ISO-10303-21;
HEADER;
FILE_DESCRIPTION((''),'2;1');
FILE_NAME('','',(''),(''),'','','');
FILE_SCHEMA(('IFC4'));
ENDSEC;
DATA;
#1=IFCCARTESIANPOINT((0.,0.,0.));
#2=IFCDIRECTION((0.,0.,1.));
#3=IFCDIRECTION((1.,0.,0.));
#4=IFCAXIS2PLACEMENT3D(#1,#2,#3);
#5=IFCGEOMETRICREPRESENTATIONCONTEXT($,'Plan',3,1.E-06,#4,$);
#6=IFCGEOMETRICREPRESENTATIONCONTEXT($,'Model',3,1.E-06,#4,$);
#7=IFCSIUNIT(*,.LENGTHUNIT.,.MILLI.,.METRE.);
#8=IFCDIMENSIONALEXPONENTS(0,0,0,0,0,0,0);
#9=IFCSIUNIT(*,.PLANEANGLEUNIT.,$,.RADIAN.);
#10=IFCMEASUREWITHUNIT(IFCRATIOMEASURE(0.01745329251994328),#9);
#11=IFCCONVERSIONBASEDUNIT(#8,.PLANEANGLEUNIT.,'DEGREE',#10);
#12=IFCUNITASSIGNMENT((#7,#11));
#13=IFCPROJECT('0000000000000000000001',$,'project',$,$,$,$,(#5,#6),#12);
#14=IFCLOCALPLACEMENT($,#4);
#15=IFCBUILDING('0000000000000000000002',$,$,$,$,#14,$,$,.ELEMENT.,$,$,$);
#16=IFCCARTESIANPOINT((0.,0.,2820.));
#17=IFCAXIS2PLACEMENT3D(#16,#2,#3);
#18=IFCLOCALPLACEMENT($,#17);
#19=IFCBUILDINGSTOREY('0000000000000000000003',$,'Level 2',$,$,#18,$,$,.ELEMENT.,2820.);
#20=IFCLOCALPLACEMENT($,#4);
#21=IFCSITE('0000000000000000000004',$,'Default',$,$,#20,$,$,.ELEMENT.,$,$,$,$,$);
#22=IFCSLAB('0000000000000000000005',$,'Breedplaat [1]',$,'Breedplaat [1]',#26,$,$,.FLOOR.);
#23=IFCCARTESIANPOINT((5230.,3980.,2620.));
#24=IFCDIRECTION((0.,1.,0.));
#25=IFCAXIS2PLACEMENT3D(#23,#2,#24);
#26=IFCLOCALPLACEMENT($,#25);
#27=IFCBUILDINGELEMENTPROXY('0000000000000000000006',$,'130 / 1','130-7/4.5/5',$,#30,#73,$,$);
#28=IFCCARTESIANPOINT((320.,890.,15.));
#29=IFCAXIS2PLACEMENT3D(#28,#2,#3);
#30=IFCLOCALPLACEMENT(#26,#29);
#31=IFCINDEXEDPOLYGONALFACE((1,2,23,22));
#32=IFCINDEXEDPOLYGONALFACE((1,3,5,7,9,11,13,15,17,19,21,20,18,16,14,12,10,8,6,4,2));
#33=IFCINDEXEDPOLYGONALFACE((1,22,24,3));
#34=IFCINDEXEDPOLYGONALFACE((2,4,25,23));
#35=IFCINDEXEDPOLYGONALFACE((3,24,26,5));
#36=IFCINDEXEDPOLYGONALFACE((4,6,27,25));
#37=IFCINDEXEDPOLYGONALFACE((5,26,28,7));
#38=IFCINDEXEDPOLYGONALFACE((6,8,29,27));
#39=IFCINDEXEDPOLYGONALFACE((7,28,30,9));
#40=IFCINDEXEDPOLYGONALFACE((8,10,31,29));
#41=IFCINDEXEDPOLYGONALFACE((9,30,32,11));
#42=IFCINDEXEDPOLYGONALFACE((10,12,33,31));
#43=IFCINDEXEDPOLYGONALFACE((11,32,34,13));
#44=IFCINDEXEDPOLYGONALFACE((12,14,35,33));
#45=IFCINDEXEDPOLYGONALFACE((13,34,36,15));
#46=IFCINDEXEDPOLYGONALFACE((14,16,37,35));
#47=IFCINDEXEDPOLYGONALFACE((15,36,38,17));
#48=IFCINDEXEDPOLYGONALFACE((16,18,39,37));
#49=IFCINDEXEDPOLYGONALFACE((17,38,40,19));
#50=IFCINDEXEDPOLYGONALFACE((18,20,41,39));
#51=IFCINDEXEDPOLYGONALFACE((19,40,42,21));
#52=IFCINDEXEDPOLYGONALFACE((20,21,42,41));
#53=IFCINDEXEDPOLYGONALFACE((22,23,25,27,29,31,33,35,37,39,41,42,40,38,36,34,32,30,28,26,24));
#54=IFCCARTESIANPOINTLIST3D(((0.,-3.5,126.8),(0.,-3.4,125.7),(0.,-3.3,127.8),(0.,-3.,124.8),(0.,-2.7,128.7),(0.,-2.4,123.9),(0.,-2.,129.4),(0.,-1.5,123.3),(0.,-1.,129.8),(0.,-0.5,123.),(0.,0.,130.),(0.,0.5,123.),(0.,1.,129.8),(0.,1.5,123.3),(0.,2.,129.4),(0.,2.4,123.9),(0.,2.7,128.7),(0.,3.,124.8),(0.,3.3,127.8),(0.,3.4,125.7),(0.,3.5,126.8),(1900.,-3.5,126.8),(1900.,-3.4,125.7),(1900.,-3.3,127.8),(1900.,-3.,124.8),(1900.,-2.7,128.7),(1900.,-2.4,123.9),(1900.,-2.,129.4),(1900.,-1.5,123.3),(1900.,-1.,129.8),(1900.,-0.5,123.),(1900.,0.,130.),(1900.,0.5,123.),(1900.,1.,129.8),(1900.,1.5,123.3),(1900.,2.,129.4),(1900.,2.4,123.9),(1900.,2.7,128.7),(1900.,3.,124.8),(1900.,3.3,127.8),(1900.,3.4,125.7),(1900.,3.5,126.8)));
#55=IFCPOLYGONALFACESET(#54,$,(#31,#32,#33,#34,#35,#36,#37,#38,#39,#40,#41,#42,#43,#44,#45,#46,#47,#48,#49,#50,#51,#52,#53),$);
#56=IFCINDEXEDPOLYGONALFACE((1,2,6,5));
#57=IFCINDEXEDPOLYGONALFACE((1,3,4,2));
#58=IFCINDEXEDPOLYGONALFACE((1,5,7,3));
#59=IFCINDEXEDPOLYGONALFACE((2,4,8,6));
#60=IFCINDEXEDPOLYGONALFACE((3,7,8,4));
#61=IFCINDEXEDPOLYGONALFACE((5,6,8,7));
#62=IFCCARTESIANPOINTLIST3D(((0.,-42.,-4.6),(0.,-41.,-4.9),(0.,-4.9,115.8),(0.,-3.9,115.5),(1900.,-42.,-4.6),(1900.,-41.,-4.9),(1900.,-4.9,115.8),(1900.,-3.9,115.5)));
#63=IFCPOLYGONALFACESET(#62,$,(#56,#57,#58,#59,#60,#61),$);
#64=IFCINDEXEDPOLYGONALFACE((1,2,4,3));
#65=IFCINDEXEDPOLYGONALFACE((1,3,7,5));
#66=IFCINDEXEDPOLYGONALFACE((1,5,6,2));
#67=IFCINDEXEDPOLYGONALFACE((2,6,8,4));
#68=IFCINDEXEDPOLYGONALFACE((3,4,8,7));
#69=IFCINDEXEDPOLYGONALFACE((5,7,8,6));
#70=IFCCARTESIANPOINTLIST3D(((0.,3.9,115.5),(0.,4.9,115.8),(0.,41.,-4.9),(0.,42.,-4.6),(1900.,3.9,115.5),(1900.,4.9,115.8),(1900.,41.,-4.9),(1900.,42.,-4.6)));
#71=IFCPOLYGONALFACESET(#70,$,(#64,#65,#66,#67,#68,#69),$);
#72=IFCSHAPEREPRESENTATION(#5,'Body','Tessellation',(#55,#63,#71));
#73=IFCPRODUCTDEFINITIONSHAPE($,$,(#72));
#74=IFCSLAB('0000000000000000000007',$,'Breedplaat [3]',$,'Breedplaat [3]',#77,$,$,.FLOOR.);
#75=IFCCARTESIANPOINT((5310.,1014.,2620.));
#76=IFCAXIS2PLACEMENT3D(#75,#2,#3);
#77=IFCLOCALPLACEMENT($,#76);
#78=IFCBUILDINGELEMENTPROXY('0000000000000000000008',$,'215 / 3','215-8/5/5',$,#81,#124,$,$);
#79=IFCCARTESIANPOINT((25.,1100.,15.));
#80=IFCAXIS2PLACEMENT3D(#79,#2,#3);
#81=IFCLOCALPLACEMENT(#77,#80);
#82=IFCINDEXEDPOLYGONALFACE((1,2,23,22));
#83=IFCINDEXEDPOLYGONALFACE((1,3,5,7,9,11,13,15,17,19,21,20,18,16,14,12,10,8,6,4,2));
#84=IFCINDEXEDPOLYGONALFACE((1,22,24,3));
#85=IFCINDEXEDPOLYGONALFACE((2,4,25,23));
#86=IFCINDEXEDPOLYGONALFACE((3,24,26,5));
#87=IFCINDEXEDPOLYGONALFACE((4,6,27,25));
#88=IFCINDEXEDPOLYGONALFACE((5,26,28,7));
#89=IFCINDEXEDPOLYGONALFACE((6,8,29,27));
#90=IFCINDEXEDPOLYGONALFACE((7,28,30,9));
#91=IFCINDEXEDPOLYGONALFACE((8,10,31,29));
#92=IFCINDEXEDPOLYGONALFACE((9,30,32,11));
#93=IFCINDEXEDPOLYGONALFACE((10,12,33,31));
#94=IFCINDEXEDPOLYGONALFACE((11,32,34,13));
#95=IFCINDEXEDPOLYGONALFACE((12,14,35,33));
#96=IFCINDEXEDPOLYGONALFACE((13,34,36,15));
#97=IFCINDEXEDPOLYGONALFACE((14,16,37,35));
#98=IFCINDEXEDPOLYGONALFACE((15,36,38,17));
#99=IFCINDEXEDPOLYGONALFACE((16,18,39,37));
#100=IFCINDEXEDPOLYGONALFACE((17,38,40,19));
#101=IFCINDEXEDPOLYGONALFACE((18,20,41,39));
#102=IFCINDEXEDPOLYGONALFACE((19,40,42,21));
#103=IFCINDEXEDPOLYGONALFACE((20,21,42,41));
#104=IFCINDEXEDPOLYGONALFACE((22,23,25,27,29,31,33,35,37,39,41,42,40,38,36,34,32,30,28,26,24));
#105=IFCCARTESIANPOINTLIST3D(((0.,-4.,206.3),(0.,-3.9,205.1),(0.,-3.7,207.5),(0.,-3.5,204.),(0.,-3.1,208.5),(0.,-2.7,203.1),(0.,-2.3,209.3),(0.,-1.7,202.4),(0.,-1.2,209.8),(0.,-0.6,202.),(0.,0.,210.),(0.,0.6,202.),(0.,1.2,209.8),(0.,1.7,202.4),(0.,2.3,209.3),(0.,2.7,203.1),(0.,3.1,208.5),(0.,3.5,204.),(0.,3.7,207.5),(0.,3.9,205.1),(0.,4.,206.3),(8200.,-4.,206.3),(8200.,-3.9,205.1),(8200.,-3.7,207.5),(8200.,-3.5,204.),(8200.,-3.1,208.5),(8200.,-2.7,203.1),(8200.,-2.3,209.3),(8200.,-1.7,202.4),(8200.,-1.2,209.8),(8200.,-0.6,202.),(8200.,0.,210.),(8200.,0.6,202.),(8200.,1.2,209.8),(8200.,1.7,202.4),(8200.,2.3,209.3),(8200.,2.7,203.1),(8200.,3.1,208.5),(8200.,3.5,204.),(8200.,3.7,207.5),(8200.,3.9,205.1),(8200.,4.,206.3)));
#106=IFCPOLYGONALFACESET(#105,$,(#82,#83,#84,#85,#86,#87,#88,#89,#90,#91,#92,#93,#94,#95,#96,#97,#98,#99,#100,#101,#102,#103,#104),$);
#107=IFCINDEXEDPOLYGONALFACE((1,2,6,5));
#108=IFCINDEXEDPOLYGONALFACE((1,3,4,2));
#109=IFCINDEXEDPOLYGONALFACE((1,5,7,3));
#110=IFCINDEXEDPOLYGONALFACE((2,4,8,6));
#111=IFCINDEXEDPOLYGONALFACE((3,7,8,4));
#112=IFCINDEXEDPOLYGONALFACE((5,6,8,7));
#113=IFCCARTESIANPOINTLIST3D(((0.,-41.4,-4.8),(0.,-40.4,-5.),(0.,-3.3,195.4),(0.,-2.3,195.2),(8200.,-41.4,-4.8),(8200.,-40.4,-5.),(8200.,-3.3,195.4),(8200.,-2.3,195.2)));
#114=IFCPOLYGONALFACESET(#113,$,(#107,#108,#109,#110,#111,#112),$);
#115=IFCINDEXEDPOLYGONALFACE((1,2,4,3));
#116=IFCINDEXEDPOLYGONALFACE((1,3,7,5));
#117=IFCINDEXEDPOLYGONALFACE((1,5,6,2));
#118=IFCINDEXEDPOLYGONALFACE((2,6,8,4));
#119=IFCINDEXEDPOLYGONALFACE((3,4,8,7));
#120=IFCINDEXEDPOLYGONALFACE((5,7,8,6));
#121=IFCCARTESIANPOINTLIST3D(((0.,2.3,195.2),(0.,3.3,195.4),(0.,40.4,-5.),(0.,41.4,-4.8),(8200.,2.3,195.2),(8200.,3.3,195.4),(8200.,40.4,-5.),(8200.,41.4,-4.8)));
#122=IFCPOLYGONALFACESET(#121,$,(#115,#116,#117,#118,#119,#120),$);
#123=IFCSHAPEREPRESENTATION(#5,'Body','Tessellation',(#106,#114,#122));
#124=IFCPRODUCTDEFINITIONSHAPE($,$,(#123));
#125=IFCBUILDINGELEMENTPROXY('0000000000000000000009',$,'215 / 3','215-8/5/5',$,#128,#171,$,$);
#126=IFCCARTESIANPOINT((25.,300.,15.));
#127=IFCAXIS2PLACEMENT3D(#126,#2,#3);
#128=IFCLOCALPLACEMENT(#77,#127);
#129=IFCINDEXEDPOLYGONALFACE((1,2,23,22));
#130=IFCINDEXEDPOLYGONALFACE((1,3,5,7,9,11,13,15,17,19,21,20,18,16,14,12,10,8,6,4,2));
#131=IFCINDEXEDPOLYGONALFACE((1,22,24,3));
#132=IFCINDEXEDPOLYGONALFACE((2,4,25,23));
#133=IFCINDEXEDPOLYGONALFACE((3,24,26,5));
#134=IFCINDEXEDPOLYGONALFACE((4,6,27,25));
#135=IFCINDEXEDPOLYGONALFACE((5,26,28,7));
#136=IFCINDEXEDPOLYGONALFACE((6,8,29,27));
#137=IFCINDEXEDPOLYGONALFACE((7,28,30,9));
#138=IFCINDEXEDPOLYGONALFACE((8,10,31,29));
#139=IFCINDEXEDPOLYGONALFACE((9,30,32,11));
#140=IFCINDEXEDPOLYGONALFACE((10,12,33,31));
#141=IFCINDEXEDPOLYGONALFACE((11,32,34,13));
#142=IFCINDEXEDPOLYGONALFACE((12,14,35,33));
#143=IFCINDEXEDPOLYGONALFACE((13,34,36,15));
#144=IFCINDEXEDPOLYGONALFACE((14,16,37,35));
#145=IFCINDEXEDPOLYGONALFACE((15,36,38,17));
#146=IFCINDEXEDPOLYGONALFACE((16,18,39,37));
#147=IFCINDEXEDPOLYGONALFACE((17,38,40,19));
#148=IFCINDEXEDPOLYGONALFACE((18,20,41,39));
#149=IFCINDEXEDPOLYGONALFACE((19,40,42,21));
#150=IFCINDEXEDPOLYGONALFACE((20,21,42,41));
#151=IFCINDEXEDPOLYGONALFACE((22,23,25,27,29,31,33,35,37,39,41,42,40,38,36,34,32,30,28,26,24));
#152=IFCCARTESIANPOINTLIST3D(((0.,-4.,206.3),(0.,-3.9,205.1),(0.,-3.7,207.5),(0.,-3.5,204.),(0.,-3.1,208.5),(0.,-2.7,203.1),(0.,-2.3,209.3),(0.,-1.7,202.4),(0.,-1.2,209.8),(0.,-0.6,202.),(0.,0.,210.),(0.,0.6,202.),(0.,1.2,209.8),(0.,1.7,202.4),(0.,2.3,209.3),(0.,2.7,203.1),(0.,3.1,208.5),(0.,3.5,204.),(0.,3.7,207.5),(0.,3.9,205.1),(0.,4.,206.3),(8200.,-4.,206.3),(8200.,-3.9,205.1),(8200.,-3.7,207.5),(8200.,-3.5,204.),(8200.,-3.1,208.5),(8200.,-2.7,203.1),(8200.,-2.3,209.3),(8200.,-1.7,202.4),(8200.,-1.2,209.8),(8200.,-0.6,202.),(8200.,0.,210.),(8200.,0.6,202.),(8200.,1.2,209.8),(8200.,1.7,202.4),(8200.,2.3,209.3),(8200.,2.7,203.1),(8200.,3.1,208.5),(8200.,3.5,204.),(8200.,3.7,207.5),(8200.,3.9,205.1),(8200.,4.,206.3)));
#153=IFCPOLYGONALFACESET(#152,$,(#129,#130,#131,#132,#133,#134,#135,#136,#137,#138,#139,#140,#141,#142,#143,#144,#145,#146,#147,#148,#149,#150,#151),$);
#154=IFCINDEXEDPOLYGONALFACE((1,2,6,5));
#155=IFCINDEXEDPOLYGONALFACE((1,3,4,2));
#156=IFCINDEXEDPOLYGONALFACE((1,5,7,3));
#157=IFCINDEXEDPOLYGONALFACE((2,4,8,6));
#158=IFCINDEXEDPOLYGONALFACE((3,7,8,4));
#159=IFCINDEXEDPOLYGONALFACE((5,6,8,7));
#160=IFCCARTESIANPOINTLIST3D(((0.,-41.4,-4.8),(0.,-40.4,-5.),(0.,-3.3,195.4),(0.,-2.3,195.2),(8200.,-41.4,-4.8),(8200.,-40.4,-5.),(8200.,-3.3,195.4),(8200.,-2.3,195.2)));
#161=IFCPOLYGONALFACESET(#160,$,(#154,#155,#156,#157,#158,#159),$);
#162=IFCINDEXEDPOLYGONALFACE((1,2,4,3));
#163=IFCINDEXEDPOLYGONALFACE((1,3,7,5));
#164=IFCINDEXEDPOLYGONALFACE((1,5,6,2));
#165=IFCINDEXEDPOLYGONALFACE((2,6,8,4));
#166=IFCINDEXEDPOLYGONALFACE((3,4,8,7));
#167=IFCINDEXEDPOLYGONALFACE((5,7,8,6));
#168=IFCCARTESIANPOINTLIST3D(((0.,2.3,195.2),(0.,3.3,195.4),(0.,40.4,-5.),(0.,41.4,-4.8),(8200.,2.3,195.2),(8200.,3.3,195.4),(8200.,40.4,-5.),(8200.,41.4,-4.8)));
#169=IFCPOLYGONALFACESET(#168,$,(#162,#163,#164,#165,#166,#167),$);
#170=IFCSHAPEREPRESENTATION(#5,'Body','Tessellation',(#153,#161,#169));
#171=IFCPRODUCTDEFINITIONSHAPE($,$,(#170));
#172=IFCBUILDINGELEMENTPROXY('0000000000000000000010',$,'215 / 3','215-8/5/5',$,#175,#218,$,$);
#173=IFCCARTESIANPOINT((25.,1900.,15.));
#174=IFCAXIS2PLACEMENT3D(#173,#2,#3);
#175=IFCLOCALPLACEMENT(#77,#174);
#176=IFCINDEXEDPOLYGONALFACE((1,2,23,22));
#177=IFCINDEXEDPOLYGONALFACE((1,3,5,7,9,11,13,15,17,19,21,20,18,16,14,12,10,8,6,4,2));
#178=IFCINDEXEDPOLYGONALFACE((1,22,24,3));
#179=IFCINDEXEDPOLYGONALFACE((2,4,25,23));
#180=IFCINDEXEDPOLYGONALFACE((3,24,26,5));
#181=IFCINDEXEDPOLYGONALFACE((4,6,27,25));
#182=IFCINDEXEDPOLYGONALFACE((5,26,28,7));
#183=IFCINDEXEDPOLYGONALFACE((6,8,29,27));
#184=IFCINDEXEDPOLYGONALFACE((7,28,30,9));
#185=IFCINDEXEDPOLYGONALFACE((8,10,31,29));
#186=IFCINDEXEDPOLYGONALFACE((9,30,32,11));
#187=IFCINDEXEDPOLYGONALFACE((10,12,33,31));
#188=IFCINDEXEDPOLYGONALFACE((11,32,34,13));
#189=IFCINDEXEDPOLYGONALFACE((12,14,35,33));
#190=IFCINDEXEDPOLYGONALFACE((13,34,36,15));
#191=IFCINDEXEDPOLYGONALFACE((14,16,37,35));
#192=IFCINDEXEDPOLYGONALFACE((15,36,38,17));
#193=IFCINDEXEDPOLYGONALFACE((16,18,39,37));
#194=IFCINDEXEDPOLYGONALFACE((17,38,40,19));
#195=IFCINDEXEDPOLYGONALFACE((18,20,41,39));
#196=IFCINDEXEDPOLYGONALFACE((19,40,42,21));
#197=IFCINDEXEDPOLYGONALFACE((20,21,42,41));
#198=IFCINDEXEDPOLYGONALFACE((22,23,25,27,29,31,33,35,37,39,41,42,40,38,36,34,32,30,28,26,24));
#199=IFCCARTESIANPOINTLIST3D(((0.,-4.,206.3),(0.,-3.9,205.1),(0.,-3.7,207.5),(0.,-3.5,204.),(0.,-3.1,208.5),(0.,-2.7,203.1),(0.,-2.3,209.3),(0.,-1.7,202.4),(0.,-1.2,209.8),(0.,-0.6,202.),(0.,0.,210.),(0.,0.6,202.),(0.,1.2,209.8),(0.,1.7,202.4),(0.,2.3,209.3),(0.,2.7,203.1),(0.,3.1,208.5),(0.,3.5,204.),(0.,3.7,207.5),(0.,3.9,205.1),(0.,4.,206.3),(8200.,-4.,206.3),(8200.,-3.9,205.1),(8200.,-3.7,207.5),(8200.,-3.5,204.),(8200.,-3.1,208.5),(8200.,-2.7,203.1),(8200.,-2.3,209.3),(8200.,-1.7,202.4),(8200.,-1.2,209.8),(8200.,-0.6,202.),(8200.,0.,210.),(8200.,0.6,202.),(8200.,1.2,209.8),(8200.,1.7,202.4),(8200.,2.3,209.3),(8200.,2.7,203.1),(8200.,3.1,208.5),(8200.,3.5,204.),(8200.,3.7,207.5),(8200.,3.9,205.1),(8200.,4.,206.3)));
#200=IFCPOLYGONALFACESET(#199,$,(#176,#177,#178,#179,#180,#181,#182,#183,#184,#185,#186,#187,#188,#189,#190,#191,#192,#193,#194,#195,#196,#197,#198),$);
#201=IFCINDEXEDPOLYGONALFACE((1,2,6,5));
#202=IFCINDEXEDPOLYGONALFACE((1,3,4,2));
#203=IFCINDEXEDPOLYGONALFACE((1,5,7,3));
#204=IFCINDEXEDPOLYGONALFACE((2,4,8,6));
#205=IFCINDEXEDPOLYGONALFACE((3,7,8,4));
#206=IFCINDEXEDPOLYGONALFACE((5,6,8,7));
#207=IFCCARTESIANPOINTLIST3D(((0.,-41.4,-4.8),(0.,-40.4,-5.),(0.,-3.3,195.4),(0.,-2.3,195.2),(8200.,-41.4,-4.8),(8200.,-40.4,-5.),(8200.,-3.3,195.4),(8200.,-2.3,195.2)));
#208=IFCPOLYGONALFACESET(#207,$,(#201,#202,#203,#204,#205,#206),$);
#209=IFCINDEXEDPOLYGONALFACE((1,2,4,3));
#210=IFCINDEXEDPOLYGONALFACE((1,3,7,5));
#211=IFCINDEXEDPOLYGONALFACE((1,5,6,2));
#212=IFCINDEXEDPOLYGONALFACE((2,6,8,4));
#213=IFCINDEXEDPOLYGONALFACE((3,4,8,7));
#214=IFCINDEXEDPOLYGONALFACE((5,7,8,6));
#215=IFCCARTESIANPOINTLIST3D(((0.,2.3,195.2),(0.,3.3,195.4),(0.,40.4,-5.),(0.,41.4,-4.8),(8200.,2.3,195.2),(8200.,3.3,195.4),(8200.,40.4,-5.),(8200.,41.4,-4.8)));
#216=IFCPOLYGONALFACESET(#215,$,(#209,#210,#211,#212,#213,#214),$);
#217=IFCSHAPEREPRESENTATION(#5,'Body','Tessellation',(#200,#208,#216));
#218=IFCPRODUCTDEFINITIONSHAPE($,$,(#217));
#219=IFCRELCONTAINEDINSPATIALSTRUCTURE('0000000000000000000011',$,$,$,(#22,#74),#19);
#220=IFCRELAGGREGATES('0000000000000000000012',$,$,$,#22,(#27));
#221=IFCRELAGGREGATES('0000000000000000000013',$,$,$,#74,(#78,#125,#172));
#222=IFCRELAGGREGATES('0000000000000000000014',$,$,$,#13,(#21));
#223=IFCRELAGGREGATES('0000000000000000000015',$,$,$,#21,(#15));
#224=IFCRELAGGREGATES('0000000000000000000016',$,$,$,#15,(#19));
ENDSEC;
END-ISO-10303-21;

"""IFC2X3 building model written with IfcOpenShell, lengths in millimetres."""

from ifc_helpers import new_model, entity, si_unit, converted_unit, frame, origin_with_axes, origin_2d_with_axis, place, context, project, spatial, rectangle, circle, extrude, element, aggregate, save


model = new_model("IFC2X3")

# Units and contexts
plan_context = context("Plan", 3, precision=1e-06, world=origin_with_axes())
model_context = context("Model", 3, precision=1e-06, world=origin_with_axes())
ifc_project = project(units=[si_unit("LENGTHUNIT", "METRE", prefix="MILLI"), converted_unit("PLANEANGLEUNIT", "DEGREE", entity("IfcRatioMeasure", 0.01745329251994328), si_unit("PLANEANGLEUNIT", "RADIAN"), dimensions=[0, 0, 0, 0, 0, 0, 0])], contexts=[plan_context, model_context])

# Site, building, storey
site_placement = place(None, origin_with_axes())
site = spatial("IfcSite", under=ifc_project, at=site_placement, Name="Default", CompositionType="ELEMENT")
building_placement = place(None, origin_with_axes())
building = spatial("IfcBuilding", under=site, at=building_placement, CompositionType="ELEMENT")
storey_placement = place(None, frame((0.0, 0.0, 2820.0), z_axis=(0.0, 0.0, 1.0), x_axis=(1.0, 0.0, 0.0)))
storey = spatial("IfcBuildingStorey", under=building, at=storey_placement, Name="Level 2", CompositionType="ELEMENT", Elevation=2820.0)

# Slab, building element proxy
slab_1_placement = place(None, frame((5230.0, 3980.0, 2620.0), z_axis=(0.0, 0.0, 1.0), x_axis=(0.0, 1.0, 0.0)))
slab_1 = element("IfcSlab", 1, at=slab_1_placement, inside=storey, Name="Breedplaat [1]", ObjectType="Breedplaat [1]", PredefinedType="FLOOR")
proxy_1_placement = place(slab_1_placement, frame((320.0, 890.0, 15.0), z_axis=(0.0, 0.0, 1.0), x_axis=(1.0, 0.0, 0.0)))
proxy_1 = element("IfcBuildingElementProxy", 2, at=proxy_1_placement, Name="130 / 1", Description="130-7/4.5/5", context=plan_context, shape_type="SweptSolid", body=[
    extrude(circle(Radius=3.5, at=origin_2d_with_axis()), frame((0.0, 0.0, 126.5), z_axis=(1.0, 0.0, 0.0), x_axis=(0.0, 0.0, 1.0)), (0.0, 0.0, 1.0), 1900.0),
    extrude(rectangle(XDim=126.0, YDim=1.0, at=origin_2d_with_axis()), frame((0.0, -22.9, 55.4), z_axis=(1.0, 0.0, 0.0), x_axis=(0.0, 0.294086, 0.955779)), (0.0, 0.0, 1.0), 1900.0),
    extrude(rectangle(XDim=126.0, YDim=1.0, at=origin_2d_with_axis()), frame((0.0, 22.9, 55.4), z_axis=(1.0, 0.0, 0.0), x_axis=(0.0, -0.294086, 0.955779)), (0.0, 0.0, 1.0), 1900.0),
])
aggregate(slab_1, [proxy_1])

# Slab, building element proxies
slab_2_placement = place(None, frame((5310.0, 1014.0, 2620.0), z_axis=(0.0, 0.0, 1.0), x_axis=(1.0, 0.0, 0.0)))
slab_2 = element("IfcSlab", 3, at=slab_2_placement, inside=storey, Name="Breedplaat [3]", ObjectType="Breedplaat [3]", PredefinedType="FLOOR")
proxy_2_placement = place(slab_2_placement, frame((25.0, 1100.0, 15.0), z_axis=(0.0, 0.0, 1.0), x_axis=(1.0, 0.0, 0.0)))
proxy_2 = element("IfcBuildingElementProxy", 4, at=proxy_2_placement, Name="215 / 3", Description="215-8/5/5", context=plan_context, shape_type="SweptSolid", body=[
    extrude(circle(Radius=4.0, at=origin_2d_with_axis()), frame((0.0, 0.0, 206.0), z_axis=(1.0, 0.0, 0.0), x_axis=(0.0, 0.0, 1.0)), (0.0, 0.0, 1.0), 8200.0),
    extrude(rectangle(XDim=203.8, YDim=1.0, at=origin_2d_with_axis()), frame((0.0, -21.9, 95.2), z_axis=(1.0, 0.0, 0.0), x_axis=(0.0, 0.187112, 0.982339)), (0.0, 0.0, 1.0), 8200.0),
    extrude(rectangle(XDim=203.8, YDim=1.0, at=origin_2d_with_axis()), frame((0.0, 21.9, 95.2), z_axis=(1.0, 0.0, 0.0), x_axis=(0.0, -0.187112, 0.982339)), (0.0, 0.0, 1.0), 8200.0),
])
proxy_3_placement = place(slab_2_placement, frame((25.0, 300.0, 15.0), z_axis=(0.0, 0.0, 1.0), x_axis=(1.0, 0.0, 0.0)))
proxy_3 = element("IfcBuildingElementProxy", 5, at=proxy_3_placement, Name="215 / 3", Description="215-8/5/5", context=plan_context, shape_type="SweptSolid", body=[
    extrude(circle(Radius=4.0, at=origin_2d_with_axis()), frame((0.0, 0.0, 206.0), z_axis=(1.0, 0.0, 0.0), x_axis=(0.0, 0.0, 1.0)), (0.0, 0.0, 1.0), 8200.0),
    extrude(rectangle(XDim=203.8, YDim=1.0, at=origin_2d_with_axis()), frame((0.0, -21.9, 95.2), z_axis=(1.0, 0.0, 0.0), x_axis=(0.0, 0.187112, 0.982339)), (0.0, 0.0, 1.0), 8200.0),
    extrude(rectangle(XDim=203.8, YDim=1.0, at=origin_2d_with_axis()), frame((0.0, 21.9, 95.2), z_axis=(1.0, 0.0, 0.0), x_axis=(0.0, -0.187112, 0.982339)), (0.0, 0.0, 1.0), 8200.0),
])
proxy_4_placement = place(slab_2_placement, frame((25.0, 1900.0, 15.0), z_axis=(0.0, 0.0, 1.0), x_axis=(1.0, 0.0, 0.0)))
proxy_4 = element("IfcBuildingElementProxy", 6, at=proxy_4_placement, Name="215 / 3", Description="215-8/5/5", context=plan_context, shape_type="SweptSolid", body=[
    extrude(circle(Radius=4.0, at=origin_2d_with_axis()), frame((0.0, 0.0, 206.0), z_axis=(1.0, 0.0, 0.0), x_axis=(0.0, 0.0, 1.0)), (0.0, 0.0, 1.0), 8200.0),
    extrude(rectangle(XDim=203.8, YDim=1.0, at=origin_2d_with_axis()), frame((0.0, -21.9, 95.2), z_axis=(1.0, 0.0, 0.0), x_axis=(0.0, 0.187112, 0.982339)), (0.0, 0.0, 1.0), 8200.0),
    extrude(rectangle(XDim=203.8, YDim=1.0, at=origin_2d_with_axis()), frame((0.0, 21.9, 95.2), z_axis=(1.0, 0.0, 0.0), x_axis=(0.0, -0.187112, 0.982339)), (0.0, 0.0, 1.0), 8200.0),
])
aggregate(slab_2, [proxy_2, proxy_3, proxy_4])

save(model, "model.ifc")
